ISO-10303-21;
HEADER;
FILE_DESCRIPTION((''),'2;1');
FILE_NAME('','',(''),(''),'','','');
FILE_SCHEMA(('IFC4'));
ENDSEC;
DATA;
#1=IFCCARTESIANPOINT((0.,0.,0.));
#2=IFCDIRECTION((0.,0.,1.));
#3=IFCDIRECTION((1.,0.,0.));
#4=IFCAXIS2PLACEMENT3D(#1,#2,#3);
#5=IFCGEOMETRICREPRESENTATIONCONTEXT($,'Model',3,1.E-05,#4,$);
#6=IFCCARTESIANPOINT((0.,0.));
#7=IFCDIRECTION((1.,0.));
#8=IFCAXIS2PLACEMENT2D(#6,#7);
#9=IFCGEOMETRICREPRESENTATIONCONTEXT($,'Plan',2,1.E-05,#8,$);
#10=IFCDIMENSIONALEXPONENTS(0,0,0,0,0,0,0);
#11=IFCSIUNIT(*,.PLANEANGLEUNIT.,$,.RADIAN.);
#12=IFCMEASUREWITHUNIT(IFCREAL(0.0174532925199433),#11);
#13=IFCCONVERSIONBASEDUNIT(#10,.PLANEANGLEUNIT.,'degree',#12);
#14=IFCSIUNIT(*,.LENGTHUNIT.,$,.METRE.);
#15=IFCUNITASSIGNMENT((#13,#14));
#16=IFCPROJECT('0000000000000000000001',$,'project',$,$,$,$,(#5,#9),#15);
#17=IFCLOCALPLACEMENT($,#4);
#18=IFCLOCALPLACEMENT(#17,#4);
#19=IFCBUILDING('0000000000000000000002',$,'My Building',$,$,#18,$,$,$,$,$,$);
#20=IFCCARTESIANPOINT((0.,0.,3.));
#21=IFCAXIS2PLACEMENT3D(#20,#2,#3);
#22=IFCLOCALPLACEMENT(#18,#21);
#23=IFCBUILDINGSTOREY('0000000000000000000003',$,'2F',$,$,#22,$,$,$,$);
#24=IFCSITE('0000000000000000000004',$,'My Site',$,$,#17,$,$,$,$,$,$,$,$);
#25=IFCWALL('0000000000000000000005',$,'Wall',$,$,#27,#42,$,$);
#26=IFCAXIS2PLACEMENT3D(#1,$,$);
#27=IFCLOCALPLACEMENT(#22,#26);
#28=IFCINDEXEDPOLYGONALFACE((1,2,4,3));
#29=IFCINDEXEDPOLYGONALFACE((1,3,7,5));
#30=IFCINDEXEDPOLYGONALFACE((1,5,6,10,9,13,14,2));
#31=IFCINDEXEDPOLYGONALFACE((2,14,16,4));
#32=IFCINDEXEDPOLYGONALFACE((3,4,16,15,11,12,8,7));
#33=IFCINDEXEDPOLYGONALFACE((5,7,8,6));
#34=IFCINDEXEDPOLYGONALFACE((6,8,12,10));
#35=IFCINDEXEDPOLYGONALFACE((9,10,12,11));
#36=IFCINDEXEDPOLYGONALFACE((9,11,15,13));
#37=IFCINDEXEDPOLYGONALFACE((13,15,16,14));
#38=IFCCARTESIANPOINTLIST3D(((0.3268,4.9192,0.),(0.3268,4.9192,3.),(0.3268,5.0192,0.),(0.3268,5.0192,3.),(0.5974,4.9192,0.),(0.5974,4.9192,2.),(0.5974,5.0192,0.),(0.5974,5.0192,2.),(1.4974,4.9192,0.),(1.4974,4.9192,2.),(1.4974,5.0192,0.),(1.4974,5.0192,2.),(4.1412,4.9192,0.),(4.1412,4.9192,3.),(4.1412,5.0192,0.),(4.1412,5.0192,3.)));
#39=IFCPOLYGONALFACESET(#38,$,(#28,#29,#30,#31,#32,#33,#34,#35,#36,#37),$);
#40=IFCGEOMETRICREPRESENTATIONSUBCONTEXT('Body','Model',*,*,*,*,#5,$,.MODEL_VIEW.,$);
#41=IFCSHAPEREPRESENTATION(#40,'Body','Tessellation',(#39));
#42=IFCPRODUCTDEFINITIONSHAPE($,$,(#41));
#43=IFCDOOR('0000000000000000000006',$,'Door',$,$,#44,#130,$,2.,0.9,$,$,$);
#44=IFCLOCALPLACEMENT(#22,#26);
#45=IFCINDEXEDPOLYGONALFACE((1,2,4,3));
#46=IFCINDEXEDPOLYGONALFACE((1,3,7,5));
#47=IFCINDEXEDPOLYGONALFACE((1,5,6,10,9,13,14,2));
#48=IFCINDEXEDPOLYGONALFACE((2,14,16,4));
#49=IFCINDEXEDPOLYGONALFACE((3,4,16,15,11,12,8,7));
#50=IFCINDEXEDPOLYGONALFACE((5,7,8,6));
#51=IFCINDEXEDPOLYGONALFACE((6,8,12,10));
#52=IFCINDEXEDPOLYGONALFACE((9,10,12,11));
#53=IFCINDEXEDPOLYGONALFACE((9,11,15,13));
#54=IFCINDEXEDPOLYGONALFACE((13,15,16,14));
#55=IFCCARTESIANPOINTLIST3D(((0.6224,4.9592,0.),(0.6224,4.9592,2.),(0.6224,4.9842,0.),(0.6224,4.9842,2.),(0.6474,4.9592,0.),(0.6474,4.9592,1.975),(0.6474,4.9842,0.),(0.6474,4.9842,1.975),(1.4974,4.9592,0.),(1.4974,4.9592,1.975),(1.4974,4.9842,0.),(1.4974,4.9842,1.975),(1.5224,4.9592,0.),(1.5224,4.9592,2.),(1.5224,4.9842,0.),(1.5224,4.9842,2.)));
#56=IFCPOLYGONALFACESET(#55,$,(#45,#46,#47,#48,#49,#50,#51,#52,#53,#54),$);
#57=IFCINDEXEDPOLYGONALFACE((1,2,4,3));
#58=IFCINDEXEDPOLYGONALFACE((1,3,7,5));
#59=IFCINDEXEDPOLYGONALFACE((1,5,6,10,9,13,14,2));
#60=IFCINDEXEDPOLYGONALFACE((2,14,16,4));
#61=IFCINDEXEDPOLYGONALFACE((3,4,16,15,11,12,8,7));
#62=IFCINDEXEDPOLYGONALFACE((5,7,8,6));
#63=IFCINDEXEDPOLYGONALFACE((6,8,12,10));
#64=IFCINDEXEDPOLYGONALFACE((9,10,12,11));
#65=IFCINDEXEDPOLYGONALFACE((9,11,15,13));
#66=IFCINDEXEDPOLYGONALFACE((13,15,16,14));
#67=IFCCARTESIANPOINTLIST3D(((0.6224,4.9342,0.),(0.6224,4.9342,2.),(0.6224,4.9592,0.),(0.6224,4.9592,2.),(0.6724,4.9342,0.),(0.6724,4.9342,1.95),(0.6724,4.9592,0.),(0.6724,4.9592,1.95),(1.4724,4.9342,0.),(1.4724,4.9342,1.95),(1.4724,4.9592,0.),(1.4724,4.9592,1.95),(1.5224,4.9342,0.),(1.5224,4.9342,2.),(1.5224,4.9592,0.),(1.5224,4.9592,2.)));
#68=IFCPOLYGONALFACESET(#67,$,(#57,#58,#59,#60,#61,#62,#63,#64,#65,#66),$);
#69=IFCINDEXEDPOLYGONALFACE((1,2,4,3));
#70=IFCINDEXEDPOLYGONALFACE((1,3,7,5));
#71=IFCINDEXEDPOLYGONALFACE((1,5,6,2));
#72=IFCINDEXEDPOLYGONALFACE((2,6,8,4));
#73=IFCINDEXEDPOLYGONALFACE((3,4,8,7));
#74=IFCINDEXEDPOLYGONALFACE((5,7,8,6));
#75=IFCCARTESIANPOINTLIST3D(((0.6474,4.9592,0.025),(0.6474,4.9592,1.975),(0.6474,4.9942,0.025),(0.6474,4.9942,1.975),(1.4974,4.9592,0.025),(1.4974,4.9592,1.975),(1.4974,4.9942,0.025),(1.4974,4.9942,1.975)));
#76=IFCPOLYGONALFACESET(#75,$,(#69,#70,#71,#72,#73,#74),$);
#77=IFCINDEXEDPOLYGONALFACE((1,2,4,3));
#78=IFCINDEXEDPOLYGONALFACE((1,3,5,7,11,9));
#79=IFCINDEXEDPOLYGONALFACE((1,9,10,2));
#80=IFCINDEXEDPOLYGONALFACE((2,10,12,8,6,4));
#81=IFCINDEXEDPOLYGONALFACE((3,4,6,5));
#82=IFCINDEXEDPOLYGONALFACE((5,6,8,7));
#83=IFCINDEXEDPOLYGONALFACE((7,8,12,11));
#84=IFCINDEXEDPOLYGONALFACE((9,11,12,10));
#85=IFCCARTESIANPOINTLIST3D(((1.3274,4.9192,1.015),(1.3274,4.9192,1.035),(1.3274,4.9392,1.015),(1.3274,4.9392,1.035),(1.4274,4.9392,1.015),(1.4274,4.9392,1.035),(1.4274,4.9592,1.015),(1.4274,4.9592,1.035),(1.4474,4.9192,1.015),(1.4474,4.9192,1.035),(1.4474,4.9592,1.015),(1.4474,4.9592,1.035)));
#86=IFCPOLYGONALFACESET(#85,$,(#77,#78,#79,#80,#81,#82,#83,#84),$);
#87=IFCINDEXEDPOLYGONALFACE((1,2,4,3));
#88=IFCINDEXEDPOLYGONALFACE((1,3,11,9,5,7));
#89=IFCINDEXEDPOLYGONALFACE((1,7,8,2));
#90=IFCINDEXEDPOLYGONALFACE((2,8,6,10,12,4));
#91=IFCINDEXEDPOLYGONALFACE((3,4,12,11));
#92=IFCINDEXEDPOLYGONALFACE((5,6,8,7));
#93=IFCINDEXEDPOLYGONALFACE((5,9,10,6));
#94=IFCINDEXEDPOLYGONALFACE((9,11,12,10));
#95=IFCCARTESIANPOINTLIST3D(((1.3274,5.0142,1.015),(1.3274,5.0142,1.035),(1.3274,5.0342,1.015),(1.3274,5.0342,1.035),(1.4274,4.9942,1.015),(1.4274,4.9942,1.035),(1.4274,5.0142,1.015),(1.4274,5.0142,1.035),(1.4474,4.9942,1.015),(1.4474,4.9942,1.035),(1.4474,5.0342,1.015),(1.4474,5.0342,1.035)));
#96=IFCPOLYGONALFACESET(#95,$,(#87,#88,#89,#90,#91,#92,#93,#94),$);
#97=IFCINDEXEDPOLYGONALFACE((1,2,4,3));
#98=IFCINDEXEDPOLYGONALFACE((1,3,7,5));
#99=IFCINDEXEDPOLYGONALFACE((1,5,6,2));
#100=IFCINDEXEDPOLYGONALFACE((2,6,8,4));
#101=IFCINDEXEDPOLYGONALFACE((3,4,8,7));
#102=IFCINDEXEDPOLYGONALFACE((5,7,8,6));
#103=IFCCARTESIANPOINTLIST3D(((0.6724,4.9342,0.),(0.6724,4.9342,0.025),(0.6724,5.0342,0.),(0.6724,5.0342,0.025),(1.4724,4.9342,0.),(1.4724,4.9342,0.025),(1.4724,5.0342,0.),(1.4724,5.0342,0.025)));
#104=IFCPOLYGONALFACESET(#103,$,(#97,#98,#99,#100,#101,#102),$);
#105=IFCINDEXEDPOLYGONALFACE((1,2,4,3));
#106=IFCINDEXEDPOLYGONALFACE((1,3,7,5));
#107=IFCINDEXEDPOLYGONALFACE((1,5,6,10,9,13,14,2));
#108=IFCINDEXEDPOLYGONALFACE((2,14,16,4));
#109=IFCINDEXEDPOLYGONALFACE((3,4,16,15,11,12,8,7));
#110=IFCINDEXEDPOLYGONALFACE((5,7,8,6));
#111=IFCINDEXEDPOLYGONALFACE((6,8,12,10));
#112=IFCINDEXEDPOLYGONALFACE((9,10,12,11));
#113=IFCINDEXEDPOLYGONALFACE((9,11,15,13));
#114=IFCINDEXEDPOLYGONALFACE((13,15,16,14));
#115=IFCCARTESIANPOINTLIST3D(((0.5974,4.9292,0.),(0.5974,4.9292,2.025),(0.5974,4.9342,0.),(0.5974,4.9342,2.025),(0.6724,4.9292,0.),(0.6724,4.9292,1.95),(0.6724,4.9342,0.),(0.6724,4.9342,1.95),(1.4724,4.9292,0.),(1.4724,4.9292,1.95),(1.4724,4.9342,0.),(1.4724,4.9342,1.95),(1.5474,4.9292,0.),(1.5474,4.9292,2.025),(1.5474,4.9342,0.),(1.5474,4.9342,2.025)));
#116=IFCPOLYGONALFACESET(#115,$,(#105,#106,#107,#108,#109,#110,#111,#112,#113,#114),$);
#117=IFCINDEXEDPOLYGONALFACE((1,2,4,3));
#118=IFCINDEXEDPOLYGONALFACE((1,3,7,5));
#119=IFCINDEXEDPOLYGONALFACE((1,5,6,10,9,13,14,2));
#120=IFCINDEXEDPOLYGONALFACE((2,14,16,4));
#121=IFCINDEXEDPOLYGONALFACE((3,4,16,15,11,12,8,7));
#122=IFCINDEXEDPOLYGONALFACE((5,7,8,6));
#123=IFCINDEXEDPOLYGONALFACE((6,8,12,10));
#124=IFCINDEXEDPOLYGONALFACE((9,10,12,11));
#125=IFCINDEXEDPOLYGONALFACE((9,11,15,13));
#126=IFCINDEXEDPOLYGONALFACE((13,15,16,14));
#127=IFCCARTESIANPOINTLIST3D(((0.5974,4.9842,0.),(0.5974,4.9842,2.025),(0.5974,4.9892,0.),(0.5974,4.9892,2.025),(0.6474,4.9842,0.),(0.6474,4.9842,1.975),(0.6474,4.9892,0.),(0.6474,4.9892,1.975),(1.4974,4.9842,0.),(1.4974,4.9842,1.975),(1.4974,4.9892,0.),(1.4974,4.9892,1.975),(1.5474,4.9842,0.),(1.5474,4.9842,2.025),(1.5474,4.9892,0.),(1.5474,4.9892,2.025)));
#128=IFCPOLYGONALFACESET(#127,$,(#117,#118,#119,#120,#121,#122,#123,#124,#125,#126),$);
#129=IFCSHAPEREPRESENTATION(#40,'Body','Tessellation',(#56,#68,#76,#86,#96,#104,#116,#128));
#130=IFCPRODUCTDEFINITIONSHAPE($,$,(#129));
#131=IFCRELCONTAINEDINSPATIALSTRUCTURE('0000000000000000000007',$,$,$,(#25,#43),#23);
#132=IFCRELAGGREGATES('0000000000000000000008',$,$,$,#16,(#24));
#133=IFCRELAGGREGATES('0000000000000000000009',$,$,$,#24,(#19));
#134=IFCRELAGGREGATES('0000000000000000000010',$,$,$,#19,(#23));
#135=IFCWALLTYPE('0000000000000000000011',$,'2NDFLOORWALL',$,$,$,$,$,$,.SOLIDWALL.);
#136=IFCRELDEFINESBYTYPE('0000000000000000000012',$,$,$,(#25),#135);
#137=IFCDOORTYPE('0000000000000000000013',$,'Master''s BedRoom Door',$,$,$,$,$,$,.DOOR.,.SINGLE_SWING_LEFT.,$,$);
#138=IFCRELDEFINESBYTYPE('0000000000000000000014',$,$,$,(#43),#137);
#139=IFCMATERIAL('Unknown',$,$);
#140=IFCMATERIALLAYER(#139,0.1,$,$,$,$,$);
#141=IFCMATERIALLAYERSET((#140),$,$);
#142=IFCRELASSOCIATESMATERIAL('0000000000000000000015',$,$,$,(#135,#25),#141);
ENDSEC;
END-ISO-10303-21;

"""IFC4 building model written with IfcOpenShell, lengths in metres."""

from ifc_helpers import new_model, entity, si_unit, converted_unit, frame, origin_with_axes, origin_2d_with_axis, place, context, subcontext, project, spatial, line, indexed_curve, outline, extrude, shape, source, transform, mapped, material, layer, layer_set, layer_usage, type_object, type_shapes, element, fill, save


model = new_model("IFC4")

# Units and contexts
model_context = context("Model", 3, precision=1e-05, world=origin_with_axes())
plan_context = context("Plan", 2, precision=1e-05, world=origin_2d_with_axis())
body_context_1 = subcontext(model_context, "Body", "Model", "MODEL_VIEW")
body_context_2 = subcontext(plan_context, "Body", "Plan", "PLAN_VIEW")
ifc_project = project(units=[converted_unit("PLANEANGLEUNIT", "degree", entity("IfcReal", 0.0174532925199433), si_unit("PLANEANGLEUNIT", "RADIAN"), dimensions=[0, 0, 0, 0, 0, 0, 0]), si_unit("LENGTHUNIT", "METRE")], contexts=[model_context, plan_context])

# Site, building, storey
site_placement = place(None, origin_with_axes())
site = spatial("IfcSite", under=ifc_project, at=site_placement, Name="My Site")
building_placement = place(site_placement, origin_with_axes())
building = spatial("IfcBuilding", under=site, at=building_placement, Name="My Building")
storey_placement = place(building_placement, frame((0.0, 0.0, 3.0), z_axis=(0.0, 0.0, 1.0), x_axis=(1.0, 0.0, 0.0)))
storey = spatial("IfcBuildingStorey", under=building, at=storey_placement, Name="2F")

# Shared definitions
ifc_material = material(Name="Unknown")

# Shared definitions
ifc_layer_1 = layer(ifc_material, 0.1)
ifc_layer_set_1 = layer_set([ifc_layer_1])
wall_type_1 = type_object("IfcWallType", Name="2NDFLOORWALL", PredefinedType="SOLIDWALL", material=ifc_layer_set_1)

# Wall, opening, door
ifc_layer_usage_1 = layer_usage(ifc_layer_set_1, "AXIS2", "POSITIVE", 0.0)
wall_1_placement = place(storey_placement, frame((4.1412, 5.0192, 0.0), z_axis=(0.0, 0.0, 1.0), x_axis=(-1.0, 0.0, 0.0)))
wall_1 = element("IfcWall", 1, at=wall_1_placement, inside=storey, type_object=wall_type_1, material=ifc_layer_usage_1, Name="Wall", context=body_context_1, shape_type="SweptSolid", body=[
    extrude(outline(indexed_curve([(0.0, 0.0), (0.0, 0.1), (3.8144, 0.1), (3.8144, 0.0)], segments=[line(1, 2, 3, 4, 1)])), origin_with_axes(), (0.0, 0.0, 1.0), 3.0),
])
shared_shape_1 = source(origin_with_axes(), body_context_1, "Body", "SweptSolid", [
    extrude(outline(indexed_curve([(0.0, 0.0), (0.9, 0.0), (0.9, 2.0), (0.0, 2.0)], segments=[line(1, 2, 3, 4, 1)])), frame((0.0, -0.6, 0.0), z_axis=(0.0, -1.0, 0.0), x_axis=(1.0, 0.0, 0.0)), (0.0, 0.0, -1.0), 1.2),
])
opening_1_placement = place(wall_1_placement, frame((2.6438, 0.0, 0.0), z_axis=(0.0, 0.0, 1.0), x_axis=(1.0, 0.0, 0.0)))
opening_1 = element("IfcOpeningElement", 2, at=opening_1_placement, cuts=wall_1, PredefinedType="OPENING", context=body_context_1, shape_type="MappedRepresentation", body=[
    mapped(shared_shape_1, transform((0.0, 0.0, 0.0), x_axis=(1.0, 0.0, 0.0), y_axis=(0.0, 1.0, 0.0), z_axis=(0.0, 0.0, 1.0), scale=1.0)),
])
door_type_1 = type_object("IfcDoorType", Name="Master's BedRoom Door", OperationType="SINGLE_SWING_LEFT", PredefinedType="DOOR")
shared_shape_2 = source(origin_with_axes(), body_context_1, "Body", "SweptSolid", [
    extrude(outline(indexed_curve([(0.0, 0.0), (0.0, 2.0), (0.9, 2.0), (0.9, 0.0), (0.875, 0.0), (0.875, 1.975), (0.025, 1.975), (0.025, 0.0)], segments=[line(1, 2, 3, 4, 5, 6, 7, 8, 1)])), frame((0.0, 0.025, 0.0), z_axis=(0.0, -1.0, 0.0), x_axis=(1.0, 0.0, 0.0)), (0.0, 0.0, -1.0), 0.025),
    extrude(outline(indexed_curve([(0.0, 0.0), (0.0, 2.0), (0.9, 2.0), (0.9, 0.0), (0.85, 0.0), (0.85, 1.95), (0.05, 1.95), (0.05, 0.0)], segments=[line(1, 2, 3, 4, 5, 6, 7, 8, 1)])), frame((0.0, 0.0, 0.0), z_axis=(0.0, -1.0, 0.0), x_axis=(1.0, 0.0, 0.0)), (0.0, 0.0, -1.0), 0.025),
    extrude(outline(indexed_curve([(0.0, 0.0), (0.85, 0.0), (0.85, 0.035), (0.0, 0.035)], segments=[line(1, 2, 3, 4, 1)])), frame((0.025, 0.025, 0.025), z_axis=(0.0, 0.0, 1.0), x_axis=(1.0, 0.0, 0.0)), (0.0, 0.0, 1.0), 1.95),
    extrude(outline(indexed_curve([(0.0, 0.0), (0.0, -0.04), (-0.12, -0.04), (-0.12, -0.02), (-0.02, -0.02), (-0.02, 0.0)], segments=[line(1, 2, 3, 4, 5, 6, 1)])), frame((0.825, 0.025, 1.015), z_axis=(0.0, 0.0, 1.0), x_axis=(1.0, 0.0, 0.0)), (0.0, 0.0, 1.0), 0.02),
    extrude(outline(indexed_curve([(0.0, 0.0), (0.0, 0.04), (-0.12, 0.04), (-0.12, 0.02), (-0.02, 0.02), (-0.02, 0.0)], segments=[line(1, 2, 3, 4, 5, 6, 1)])), frame((0.825, 0.06, 1.015), z_axis=(0.0, 0.0, 1.0), x_axis=(1.0, 0.0, 0.0)), (0.0, 0.0, 1.0), 0.02),
    extrude(outline(indexed_curve([(0.0, 0.0), (0.8, 0.0), (0.8, 0.1), (0.0, 0.1)], segments=[line(1, 2, 3, 4, 1)])), frame((0.05, 0.0, 0.0), z_axis=(0.0, 0.0, 1.0), x_axis=(1.0, 0.0, 0.0)), (0.0, 0.0, 1.0), 0.025),
    extrude(outline(indexed_curve([(0.0, 0.0), (0.0, 2.025), (0.95, 2.025), (0.95, 0.0), (0.875, 0.0), (0.875, 1.95), (0.075, 1.95), (0.075, 0.0)], segments=[line(1, 2, 3, 4, 5, 6, 7, 8, 1)])), frame((-0.025, -0.005, 0.0), z_axis=(0.0, -1.0, 0.0), x_axis=(1.0, 0.0, 0.0)), (0.0, 0.0, -1.0), 0.005),
    extrude(outline(indexed_curve([(0.0, 0.0), (0.0, 2.025), (0.95, 2.025), (0.95, 0.0), (0.9, 0.0), (0.9, 1.975), (0.05, 1.975), (0.05, 0.0)], segments=[line(1, 2, 3, 4, 5, 6, 7, 8, 1)])), frame((-0.025, 0.05, 0.0), z_axis=(0.0, -1.0, 0.0), x_axis=(1.0, 0.0, 0.0)), (0.0, 0.0, -1.0), 0.005),
])
shared_shape_3 = source(origin_with_axes(), body_context_2, "Body", "Curve2D", [
    entity("IfcIndexedPolyCurve", entity("IfcCartesianPointList2D", [[0.0, 0.0], [0.0, 0.05], [0.025, 0.05], [0.025, 0.025], [0.05, 0.025], [0.05, 0.0]]), [entity("IfcLineIndex", [1, 2, 3, 4, 5, 6, 1])]),
    entity("IfcIndexedPolyCurve", entity("IfcCartesianPointList2D", [[0.9, 0.0], [0.9, 0.05], [0.875, 0.05], [0.875, 0.025], [0.85, 0.025], [0.85, 0.0]]), [entity("IfcLineIndex", [1, 2, 3, 4, 5, 6, 1])]),
    entity("IfcTrimmedCurve", entity("IfcEllipse", entity("IfcAxis2Placement2D", entity("IfcCartesianPoint", [0.06, 0.05]), entity("IfcDirection", [1.0, 0.0])), 0.815, 0.85), [entity("IfcCartesianPoint", [0.875, 0.05])], [entity("IfcCartesianPoint", [0.06, 0.9])], True, "CARTESIAN"),
    entity("IfcIndexedPolyCurve", entity("IfcCartesianPointList2D", [[0.025, 0.05], [0.06, 0.05], [0.06, 0.9], [0.025, 0.9]]), [entity("IfcLineIndex", [1, 2, 3, 4, 1])]),
])
type_shapes(door_type_1, [shared_shape_2, shared_shape_3])
door_1_placement = place(opening_1_placement, frame((0.875, 0.085, 0.0), z_axis=(0.0, 0.0, 1.0), x_axis=(-1.0, 0.0, 0.0)))
door_1 = element("IfcDoor", 3, at=door_1_placement, inside=storey, type_object=door_type_1, Name="Door", OverallHeight=2.0, OverallWidth=0.9, shapes=[
    shape(body_context_1, "Body", "MappedRepresentation", [mapped(shared_shape_2, transform((0.0, 0.0, 0.0), x_axis=(1.0, 0.0, 0.0), y_axis=(0.0, 1.0, 0.0), z_axis=(0.0, 0.0, 1.0), scale=1.0))]),
    shape(body_context_2, "Body", "MappedRepresentation", [mapped(shared_shape_3, transform((0.0, 0.0, 0.0), x_axis=(1.0, 0.0, 0.0), y_axis=(0.0, 1.0, 0.0), z_axis=(0.0, 0.0, 1.0), scale=1.0))]),
])
fill(opening_1, door_1)

save(model, "model.ifc")
